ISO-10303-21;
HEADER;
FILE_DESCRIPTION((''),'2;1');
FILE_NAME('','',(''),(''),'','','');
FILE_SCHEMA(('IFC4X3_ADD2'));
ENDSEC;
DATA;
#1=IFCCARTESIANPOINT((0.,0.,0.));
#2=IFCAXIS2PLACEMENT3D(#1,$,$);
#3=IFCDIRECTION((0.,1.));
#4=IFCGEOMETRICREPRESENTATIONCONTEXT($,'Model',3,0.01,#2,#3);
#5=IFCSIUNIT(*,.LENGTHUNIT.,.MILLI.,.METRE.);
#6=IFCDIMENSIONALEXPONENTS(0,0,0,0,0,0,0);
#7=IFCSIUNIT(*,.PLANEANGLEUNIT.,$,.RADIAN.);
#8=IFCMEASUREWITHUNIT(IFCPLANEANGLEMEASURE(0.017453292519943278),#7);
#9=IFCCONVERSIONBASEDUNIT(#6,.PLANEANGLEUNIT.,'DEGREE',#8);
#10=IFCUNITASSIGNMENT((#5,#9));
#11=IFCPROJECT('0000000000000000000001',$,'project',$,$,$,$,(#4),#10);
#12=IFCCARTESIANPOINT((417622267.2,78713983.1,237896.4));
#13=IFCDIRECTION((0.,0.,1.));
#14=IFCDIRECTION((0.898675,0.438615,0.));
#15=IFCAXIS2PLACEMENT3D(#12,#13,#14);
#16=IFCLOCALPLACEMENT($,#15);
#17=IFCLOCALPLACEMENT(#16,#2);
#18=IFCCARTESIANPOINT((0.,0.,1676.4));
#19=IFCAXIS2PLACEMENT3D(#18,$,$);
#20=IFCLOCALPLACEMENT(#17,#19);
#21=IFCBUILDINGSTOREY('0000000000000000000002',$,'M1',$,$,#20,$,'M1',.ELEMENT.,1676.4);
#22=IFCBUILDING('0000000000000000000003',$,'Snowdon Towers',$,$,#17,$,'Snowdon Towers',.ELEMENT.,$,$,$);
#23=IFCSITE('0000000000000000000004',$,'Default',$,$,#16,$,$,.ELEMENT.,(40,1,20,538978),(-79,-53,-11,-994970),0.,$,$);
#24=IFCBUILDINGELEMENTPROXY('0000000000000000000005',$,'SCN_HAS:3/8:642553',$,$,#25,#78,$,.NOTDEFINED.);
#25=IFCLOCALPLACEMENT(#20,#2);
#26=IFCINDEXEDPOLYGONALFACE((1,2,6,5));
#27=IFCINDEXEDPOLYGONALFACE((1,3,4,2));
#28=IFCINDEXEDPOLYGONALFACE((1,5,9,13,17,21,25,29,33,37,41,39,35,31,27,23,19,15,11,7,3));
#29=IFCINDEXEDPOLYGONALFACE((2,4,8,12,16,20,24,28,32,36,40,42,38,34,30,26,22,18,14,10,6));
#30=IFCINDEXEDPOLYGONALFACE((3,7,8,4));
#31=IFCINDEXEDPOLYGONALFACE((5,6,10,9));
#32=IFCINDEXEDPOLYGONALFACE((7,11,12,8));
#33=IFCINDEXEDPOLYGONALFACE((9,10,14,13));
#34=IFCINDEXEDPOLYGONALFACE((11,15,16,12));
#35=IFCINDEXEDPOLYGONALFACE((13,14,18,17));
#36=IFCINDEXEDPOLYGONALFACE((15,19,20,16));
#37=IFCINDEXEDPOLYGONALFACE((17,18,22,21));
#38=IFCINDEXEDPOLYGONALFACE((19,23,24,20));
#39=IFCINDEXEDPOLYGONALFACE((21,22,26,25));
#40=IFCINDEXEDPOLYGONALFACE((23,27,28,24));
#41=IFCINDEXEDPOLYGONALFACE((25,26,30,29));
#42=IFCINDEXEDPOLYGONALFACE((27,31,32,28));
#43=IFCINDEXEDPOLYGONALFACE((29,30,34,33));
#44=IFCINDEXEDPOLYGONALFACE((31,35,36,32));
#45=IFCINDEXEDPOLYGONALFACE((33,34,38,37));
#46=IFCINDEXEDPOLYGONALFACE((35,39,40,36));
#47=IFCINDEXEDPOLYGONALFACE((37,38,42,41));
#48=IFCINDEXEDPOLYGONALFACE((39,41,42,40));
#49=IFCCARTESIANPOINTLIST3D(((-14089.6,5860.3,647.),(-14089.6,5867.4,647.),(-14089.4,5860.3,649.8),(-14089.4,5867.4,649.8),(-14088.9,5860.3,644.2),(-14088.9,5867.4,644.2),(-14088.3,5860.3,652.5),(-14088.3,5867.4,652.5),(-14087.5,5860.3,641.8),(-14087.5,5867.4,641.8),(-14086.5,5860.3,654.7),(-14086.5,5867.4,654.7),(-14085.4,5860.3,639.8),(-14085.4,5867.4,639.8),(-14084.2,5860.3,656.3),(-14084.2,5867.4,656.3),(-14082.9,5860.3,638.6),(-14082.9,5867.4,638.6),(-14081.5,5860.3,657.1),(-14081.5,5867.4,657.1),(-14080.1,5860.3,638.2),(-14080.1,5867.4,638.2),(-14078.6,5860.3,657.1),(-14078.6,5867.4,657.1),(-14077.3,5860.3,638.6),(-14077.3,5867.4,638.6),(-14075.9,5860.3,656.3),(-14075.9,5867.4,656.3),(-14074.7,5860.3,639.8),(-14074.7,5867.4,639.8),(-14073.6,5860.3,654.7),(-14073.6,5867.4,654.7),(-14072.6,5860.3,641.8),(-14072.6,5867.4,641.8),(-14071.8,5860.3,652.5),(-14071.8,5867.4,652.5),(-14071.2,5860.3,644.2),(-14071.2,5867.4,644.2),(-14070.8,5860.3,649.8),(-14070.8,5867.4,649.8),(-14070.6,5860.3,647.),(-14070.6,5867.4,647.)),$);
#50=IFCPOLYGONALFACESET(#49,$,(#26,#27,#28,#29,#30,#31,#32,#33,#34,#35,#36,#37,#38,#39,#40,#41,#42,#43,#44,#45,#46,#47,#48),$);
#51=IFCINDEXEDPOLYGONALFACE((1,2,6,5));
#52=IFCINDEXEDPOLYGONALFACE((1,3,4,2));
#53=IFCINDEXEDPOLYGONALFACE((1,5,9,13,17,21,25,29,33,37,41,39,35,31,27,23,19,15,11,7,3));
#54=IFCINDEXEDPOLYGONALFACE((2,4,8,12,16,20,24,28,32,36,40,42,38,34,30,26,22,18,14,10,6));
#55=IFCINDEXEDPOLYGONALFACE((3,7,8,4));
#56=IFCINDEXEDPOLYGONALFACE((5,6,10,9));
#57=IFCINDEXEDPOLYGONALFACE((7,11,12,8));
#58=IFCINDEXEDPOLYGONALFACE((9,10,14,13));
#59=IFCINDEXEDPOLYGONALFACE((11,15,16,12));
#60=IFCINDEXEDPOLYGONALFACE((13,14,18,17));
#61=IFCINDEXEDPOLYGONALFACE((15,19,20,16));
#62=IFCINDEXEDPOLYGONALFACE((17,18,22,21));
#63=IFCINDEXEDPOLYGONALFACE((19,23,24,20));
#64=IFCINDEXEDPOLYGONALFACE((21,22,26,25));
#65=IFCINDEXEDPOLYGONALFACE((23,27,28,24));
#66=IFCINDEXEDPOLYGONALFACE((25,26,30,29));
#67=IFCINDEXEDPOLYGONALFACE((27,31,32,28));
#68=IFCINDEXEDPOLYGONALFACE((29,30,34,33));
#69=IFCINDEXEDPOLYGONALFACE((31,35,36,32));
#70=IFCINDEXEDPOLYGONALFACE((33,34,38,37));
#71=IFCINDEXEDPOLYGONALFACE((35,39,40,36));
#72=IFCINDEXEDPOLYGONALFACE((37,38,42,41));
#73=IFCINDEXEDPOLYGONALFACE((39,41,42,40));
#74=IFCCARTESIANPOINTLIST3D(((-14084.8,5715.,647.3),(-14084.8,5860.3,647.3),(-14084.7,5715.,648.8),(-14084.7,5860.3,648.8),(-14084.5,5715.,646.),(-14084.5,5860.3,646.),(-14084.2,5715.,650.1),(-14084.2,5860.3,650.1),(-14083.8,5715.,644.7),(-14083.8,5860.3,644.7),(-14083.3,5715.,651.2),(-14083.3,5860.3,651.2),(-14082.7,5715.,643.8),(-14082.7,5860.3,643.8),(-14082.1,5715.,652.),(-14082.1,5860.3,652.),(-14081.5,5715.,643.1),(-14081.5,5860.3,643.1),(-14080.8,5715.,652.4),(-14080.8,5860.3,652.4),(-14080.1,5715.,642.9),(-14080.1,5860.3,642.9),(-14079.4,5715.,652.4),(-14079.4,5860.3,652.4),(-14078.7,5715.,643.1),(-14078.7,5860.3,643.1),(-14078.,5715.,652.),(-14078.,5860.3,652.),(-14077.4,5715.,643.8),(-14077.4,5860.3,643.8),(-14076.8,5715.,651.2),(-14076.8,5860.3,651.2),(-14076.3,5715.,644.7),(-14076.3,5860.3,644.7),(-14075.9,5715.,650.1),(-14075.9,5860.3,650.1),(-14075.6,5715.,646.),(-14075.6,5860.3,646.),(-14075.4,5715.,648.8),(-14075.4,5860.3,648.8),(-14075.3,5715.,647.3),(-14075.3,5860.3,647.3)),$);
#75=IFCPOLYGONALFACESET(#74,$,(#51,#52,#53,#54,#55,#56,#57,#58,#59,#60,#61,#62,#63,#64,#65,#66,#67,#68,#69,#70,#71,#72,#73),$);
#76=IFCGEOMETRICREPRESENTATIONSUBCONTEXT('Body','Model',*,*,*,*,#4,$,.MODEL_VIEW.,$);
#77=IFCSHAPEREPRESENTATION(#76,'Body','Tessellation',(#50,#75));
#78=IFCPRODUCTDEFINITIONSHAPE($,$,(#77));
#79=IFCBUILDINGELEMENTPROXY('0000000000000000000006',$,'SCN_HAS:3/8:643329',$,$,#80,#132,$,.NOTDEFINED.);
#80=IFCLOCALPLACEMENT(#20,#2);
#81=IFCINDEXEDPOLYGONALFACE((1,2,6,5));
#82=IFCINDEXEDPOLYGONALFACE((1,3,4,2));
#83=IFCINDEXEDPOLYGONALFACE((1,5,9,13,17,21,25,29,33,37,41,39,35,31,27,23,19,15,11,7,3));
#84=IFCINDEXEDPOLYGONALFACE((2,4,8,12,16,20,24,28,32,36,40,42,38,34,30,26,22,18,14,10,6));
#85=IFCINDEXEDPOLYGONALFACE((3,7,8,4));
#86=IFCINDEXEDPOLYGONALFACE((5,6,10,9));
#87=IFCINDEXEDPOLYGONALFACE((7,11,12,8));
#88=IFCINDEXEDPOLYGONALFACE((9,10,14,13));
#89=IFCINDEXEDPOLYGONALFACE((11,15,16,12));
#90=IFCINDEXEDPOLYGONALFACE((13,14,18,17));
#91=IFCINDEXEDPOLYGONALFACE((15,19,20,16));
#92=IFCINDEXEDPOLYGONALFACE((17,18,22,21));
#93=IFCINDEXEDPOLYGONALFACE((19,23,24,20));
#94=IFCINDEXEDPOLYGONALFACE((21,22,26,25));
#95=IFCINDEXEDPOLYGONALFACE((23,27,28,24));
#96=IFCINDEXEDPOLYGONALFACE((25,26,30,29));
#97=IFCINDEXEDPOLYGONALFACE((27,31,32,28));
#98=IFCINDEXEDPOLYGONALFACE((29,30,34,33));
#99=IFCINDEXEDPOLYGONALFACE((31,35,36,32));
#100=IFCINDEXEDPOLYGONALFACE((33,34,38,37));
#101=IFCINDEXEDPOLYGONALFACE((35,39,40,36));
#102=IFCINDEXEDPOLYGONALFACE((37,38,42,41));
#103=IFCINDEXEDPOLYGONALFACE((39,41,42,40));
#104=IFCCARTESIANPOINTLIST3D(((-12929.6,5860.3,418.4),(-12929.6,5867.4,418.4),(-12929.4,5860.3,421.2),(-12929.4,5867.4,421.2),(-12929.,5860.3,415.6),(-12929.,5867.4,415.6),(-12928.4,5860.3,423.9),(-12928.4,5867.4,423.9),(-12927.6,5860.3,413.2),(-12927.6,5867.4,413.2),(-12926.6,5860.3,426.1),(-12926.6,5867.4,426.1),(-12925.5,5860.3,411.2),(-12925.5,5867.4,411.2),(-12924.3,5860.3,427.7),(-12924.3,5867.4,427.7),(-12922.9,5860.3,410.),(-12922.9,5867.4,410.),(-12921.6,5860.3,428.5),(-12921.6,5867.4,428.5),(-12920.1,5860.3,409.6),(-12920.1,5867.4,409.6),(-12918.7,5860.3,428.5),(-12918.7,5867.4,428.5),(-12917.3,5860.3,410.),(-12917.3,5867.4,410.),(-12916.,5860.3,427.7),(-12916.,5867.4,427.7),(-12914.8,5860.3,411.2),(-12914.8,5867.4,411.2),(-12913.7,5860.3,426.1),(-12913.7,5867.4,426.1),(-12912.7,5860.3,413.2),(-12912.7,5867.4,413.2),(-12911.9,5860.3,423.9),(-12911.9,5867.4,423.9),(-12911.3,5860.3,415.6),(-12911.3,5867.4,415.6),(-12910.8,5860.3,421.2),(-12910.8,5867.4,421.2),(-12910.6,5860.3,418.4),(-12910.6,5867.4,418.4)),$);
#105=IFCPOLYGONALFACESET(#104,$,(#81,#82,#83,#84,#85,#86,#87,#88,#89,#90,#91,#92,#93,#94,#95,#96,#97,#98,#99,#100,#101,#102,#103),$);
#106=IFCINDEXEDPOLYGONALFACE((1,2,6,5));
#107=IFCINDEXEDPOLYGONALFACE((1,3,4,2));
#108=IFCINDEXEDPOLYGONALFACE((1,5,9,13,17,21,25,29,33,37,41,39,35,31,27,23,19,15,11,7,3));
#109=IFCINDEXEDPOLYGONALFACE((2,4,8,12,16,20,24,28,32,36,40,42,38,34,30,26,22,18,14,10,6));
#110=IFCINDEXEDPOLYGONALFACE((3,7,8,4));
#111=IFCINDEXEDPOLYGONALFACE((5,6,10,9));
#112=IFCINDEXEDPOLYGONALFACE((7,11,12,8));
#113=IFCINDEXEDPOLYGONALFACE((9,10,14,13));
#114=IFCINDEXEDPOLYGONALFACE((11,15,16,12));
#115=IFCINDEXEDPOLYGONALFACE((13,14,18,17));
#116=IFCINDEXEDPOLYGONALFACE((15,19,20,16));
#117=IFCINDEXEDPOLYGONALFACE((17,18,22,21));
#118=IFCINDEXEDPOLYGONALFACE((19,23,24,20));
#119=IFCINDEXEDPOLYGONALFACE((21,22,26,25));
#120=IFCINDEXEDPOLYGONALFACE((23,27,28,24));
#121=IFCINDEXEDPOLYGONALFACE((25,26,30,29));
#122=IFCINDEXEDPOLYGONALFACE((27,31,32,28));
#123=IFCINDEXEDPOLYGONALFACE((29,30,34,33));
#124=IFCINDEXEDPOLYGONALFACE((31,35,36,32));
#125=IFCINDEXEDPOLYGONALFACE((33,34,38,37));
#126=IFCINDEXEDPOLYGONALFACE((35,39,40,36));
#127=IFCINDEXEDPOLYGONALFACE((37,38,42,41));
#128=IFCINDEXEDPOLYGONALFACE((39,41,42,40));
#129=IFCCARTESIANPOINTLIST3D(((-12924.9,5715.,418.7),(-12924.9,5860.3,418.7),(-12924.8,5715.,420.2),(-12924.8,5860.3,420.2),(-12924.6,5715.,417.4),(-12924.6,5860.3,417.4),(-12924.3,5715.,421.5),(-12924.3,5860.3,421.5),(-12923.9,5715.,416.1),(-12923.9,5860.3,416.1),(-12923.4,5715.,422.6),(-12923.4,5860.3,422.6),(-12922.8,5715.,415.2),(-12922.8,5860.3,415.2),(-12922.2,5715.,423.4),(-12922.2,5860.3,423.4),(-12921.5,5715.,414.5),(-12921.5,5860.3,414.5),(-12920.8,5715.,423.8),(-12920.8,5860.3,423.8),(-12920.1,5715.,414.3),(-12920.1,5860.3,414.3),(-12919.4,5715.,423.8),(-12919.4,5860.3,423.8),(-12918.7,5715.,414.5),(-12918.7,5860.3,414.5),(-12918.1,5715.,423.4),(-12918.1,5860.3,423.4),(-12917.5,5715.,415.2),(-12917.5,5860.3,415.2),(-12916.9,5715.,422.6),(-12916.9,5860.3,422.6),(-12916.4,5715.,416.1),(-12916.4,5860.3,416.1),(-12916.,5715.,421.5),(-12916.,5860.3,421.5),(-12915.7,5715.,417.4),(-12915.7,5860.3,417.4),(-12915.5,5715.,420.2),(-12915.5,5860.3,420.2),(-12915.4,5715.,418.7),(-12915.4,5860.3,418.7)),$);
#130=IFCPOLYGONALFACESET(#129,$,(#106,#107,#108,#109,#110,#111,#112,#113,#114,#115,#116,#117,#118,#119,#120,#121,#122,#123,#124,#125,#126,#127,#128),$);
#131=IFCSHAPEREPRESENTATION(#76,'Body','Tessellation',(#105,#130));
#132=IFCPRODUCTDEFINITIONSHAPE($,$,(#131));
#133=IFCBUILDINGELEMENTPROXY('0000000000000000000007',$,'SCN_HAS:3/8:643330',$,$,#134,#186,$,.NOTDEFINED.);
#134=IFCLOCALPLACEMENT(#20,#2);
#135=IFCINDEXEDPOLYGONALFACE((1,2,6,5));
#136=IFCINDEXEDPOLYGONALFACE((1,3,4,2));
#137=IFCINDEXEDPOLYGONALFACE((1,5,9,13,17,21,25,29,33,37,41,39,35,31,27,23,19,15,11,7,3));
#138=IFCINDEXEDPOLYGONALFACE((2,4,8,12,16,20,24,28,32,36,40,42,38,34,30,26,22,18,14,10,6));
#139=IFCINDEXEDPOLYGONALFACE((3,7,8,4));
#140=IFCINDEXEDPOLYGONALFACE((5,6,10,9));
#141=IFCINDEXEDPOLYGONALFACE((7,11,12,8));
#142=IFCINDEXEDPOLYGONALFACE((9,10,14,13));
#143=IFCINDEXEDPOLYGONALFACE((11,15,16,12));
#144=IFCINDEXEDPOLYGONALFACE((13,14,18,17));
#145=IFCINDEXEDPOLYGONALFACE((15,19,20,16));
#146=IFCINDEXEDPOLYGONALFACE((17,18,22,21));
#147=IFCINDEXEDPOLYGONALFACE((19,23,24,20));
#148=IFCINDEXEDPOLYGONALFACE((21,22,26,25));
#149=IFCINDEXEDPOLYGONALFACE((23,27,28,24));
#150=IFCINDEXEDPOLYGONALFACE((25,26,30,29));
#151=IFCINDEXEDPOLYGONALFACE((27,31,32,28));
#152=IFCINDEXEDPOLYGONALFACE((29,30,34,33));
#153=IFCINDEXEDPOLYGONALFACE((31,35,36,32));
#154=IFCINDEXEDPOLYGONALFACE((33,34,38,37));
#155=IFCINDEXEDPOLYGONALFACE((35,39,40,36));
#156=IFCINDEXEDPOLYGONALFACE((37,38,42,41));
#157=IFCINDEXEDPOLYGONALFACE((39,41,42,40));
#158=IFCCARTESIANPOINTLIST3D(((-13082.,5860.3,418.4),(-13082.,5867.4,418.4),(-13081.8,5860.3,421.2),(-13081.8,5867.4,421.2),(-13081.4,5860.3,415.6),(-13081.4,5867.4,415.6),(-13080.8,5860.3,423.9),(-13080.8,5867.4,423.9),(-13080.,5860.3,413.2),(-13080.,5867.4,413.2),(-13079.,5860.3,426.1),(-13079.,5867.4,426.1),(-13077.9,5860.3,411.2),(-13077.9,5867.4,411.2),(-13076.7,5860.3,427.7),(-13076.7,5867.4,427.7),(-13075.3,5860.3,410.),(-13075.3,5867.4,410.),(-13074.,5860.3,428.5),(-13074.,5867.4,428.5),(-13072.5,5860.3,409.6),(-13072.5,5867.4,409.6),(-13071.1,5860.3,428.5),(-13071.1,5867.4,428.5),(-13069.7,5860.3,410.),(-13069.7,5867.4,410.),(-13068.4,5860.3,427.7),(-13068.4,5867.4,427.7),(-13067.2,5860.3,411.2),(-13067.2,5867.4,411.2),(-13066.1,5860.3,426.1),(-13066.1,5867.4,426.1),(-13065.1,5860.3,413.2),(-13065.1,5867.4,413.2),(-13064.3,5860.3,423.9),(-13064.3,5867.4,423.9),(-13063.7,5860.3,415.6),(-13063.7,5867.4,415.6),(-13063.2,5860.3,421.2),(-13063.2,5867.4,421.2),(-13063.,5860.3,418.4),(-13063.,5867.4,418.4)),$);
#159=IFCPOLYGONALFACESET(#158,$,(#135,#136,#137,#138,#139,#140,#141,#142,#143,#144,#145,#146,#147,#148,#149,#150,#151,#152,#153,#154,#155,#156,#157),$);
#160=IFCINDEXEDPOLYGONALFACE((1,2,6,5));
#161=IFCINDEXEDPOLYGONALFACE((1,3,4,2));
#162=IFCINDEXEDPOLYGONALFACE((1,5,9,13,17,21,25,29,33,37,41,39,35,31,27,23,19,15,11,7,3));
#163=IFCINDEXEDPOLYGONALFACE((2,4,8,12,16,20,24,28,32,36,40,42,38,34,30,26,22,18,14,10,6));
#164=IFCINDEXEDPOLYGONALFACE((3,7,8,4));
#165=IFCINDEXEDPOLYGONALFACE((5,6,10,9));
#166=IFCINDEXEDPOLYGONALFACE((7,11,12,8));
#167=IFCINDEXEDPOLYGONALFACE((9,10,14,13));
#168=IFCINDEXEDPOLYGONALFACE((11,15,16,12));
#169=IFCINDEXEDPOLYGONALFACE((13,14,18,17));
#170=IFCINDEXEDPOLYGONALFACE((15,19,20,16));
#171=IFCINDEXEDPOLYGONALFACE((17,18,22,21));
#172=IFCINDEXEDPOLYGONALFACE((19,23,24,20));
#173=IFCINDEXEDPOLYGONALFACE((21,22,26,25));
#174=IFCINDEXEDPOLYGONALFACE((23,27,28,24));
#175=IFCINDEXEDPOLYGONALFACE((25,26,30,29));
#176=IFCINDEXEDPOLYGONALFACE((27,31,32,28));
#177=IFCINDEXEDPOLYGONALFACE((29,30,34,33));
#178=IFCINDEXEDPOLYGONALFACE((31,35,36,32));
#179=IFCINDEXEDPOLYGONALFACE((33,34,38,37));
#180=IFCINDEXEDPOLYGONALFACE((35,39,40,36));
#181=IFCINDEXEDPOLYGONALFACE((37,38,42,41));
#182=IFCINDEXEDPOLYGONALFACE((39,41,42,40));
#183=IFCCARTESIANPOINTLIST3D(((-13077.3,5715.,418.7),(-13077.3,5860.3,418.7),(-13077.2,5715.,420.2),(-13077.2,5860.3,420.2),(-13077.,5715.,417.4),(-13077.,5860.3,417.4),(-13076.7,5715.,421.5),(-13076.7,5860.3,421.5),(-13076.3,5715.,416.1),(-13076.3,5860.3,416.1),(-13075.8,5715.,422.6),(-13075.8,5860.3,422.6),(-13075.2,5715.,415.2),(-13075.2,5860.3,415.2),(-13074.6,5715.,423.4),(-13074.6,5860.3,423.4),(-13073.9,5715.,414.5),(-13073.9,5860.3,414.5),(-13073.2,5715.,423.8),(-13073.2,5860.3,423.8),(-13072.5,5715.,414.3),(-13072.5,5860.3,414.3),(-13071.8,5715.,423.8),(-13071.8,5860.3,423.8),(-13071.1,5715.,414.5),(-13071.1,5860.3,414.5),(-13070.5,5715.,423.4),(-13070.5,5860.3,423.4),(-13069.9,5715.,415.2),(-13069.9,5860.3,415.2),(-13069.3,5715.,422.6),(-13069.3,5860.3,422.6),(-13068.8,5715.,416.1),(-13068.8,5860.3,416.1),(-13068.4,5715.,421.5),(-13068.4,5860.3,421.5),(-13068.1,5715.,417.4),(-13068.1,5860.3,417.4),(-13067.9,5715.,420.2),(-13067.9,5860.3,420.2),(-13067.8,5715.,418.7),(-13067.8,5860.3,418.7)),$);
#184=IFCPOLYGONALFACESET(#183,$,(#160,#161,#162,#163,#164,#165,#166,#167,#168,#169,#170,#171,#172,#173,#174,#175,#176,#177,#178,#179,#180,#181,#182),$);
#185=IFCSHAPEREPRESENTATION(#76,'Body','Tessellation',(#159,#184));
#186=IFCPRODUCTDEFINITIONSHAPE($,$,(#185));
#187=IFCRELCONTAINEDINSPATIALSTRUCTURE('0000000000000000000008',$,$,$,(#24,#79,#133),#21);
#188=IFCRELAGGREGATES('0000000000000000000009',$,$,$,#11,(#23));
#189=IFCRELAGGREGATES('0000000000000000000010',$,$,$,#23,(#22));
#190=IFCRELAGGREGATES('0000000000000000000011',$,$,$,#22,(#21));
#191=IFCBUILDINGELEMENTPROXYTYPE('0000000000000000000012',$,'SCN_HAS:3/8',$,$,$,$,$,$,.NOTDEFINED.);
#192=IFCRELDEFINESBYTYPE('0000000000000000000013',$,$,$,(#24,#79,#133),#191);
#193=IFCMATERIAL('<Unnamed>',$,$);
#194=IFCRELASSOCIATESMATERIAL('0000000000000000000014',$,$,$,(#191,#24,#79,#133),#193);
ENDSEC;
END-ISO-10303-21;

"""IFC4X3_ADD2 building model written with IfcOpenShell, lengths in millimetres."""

from ifc_helpers import new_model, entity, si_unit, converted_unit, direction, frame, frame_2d, origin, place, context, subcontext, project, spatial, circle, extrude, source, transform, mapped, material, type_object, type_shapes, element, save


model = new_model("IFC4X3_ADD2")

# Units and contexts
model_context = context("Model", 3, precision=0.01, world=origin(), true_north=direction((0.0, 1.0)))
body_context = subcontext(model_context, "Body", "Model", "MODEL_VIEW")
ifc_project = project(units=[si_unit("LENGTHUNIT", "METRE", prefix="MILLI"), converted_unit("PLANEANGLEUNIT", "DEGREE", entity("IfcPlaneAngleMeasure", 0.017453292519943278), si_unit("PLANEANGLEUNIT", "RADIAN"), dimensions=[0, 0, 0, 0, 0, 0, 0])], contexts=[model_context])

# Site, building, storey
site_placement = place(None, frame((417622267.2, 78713983.1, 237896.4), z_axis=(0.0, 0.0, 1.0), x_axis=(0.898675, 0.438615, 0.0)))
site = spatial("IfcSite", under=ifc_project, at=site_placement, Name="Default", CompositionType="ELEMENT", RefLatitude=(40, 1, 20, 538978), RefLongitude=(-79, -53, -11, -994970), RefElevation=0.0)
building_placement = place(site_placement, origin())
building = spatial("IfcBuilding", under=site, at=building_placement, Name="Snowdon Towers", LongName="Snowdon Towers", CompositionType="ELEMENT")
storey_placement = place(building_placement, frame((0.0, 0.0, 1676.4)))
storey = spatial("IfcBuildingStorey", under=building, at=storey_placement, Name="M1", LongName="M1", CompositionType="ELEMENT", Elevation=1676.4)

# Building element proxies
ifc_material_1 = material(Name="<Unnamed>")
building_element_proxy_type = type_object("IfcBuildingElementProxyType", Name="SCN_HAS:3/8", PredefinedType="NOTDEFINED", material=ifc_material_1)
shared_shape_1 = source(origin(), body_context, "Body", "SweptSolid", [
    extrude(circle(Radius=9.5, at=frame_2d((0.0, 0.0), x_axis=(1.0, 0.0))), frame((0.0, 0.0, -152.4), z_axis=(0.0, 0.0, 1.0), x_axis=(0.0, -1.0, 0.0)), (0.0, 0.0, 1.0), 7.1),
    extrude(circle(Radius=4.8, at=frame_2d((0.0, 0.0), x_axis=(1.0, 0.0))), frame((0.0, 0.0, -145.3), z_axis=(0.0, 0.0, 1.0), x_axis=(0.0, -1.0, 0.0)), (0.0, 0.0, 1.0), 145.3),
])
type_shapes(building_element_proxy_type, [shared_shape_1])
for number, where, z_axis, x_axis, name in (
    (1, (-14080.1, 5715.0, 647.7), (0.0, -1.0, 0.0), (1.0, 0.0, 0.0), "SCN_HAS:3/8:642553"),
    (2, (-12920.1, 5715.0, 419.1), (0.0, -1.0, 0.0), (1.0, 0.0, 0.0), "SCN_HAS:3/8:643329"),
    (3, (-13072.5, 5715.0, 419.1), (0.0, -1.0, 0.0), (1.0, 0.0, 0.0), "SCN_HAS:3/8:643330"),
):
    element("IfcBuildingElementProxy", number, at=place(storey_placement, frame(where, z_axis=z_axis, x_axis=x_axis)), inside=storey, type_object=building_element_proxy_type, material=ifc_material_1, Name=name, PredefinedType="NOTDEFINED", context=body_context, shape_type="MappedRepresentation", body=[
        mapped(shared_shape_1, transform((0.0, 0.0, 0.0), scale=1.0)),
    ])

save(model, "model.ifc")
